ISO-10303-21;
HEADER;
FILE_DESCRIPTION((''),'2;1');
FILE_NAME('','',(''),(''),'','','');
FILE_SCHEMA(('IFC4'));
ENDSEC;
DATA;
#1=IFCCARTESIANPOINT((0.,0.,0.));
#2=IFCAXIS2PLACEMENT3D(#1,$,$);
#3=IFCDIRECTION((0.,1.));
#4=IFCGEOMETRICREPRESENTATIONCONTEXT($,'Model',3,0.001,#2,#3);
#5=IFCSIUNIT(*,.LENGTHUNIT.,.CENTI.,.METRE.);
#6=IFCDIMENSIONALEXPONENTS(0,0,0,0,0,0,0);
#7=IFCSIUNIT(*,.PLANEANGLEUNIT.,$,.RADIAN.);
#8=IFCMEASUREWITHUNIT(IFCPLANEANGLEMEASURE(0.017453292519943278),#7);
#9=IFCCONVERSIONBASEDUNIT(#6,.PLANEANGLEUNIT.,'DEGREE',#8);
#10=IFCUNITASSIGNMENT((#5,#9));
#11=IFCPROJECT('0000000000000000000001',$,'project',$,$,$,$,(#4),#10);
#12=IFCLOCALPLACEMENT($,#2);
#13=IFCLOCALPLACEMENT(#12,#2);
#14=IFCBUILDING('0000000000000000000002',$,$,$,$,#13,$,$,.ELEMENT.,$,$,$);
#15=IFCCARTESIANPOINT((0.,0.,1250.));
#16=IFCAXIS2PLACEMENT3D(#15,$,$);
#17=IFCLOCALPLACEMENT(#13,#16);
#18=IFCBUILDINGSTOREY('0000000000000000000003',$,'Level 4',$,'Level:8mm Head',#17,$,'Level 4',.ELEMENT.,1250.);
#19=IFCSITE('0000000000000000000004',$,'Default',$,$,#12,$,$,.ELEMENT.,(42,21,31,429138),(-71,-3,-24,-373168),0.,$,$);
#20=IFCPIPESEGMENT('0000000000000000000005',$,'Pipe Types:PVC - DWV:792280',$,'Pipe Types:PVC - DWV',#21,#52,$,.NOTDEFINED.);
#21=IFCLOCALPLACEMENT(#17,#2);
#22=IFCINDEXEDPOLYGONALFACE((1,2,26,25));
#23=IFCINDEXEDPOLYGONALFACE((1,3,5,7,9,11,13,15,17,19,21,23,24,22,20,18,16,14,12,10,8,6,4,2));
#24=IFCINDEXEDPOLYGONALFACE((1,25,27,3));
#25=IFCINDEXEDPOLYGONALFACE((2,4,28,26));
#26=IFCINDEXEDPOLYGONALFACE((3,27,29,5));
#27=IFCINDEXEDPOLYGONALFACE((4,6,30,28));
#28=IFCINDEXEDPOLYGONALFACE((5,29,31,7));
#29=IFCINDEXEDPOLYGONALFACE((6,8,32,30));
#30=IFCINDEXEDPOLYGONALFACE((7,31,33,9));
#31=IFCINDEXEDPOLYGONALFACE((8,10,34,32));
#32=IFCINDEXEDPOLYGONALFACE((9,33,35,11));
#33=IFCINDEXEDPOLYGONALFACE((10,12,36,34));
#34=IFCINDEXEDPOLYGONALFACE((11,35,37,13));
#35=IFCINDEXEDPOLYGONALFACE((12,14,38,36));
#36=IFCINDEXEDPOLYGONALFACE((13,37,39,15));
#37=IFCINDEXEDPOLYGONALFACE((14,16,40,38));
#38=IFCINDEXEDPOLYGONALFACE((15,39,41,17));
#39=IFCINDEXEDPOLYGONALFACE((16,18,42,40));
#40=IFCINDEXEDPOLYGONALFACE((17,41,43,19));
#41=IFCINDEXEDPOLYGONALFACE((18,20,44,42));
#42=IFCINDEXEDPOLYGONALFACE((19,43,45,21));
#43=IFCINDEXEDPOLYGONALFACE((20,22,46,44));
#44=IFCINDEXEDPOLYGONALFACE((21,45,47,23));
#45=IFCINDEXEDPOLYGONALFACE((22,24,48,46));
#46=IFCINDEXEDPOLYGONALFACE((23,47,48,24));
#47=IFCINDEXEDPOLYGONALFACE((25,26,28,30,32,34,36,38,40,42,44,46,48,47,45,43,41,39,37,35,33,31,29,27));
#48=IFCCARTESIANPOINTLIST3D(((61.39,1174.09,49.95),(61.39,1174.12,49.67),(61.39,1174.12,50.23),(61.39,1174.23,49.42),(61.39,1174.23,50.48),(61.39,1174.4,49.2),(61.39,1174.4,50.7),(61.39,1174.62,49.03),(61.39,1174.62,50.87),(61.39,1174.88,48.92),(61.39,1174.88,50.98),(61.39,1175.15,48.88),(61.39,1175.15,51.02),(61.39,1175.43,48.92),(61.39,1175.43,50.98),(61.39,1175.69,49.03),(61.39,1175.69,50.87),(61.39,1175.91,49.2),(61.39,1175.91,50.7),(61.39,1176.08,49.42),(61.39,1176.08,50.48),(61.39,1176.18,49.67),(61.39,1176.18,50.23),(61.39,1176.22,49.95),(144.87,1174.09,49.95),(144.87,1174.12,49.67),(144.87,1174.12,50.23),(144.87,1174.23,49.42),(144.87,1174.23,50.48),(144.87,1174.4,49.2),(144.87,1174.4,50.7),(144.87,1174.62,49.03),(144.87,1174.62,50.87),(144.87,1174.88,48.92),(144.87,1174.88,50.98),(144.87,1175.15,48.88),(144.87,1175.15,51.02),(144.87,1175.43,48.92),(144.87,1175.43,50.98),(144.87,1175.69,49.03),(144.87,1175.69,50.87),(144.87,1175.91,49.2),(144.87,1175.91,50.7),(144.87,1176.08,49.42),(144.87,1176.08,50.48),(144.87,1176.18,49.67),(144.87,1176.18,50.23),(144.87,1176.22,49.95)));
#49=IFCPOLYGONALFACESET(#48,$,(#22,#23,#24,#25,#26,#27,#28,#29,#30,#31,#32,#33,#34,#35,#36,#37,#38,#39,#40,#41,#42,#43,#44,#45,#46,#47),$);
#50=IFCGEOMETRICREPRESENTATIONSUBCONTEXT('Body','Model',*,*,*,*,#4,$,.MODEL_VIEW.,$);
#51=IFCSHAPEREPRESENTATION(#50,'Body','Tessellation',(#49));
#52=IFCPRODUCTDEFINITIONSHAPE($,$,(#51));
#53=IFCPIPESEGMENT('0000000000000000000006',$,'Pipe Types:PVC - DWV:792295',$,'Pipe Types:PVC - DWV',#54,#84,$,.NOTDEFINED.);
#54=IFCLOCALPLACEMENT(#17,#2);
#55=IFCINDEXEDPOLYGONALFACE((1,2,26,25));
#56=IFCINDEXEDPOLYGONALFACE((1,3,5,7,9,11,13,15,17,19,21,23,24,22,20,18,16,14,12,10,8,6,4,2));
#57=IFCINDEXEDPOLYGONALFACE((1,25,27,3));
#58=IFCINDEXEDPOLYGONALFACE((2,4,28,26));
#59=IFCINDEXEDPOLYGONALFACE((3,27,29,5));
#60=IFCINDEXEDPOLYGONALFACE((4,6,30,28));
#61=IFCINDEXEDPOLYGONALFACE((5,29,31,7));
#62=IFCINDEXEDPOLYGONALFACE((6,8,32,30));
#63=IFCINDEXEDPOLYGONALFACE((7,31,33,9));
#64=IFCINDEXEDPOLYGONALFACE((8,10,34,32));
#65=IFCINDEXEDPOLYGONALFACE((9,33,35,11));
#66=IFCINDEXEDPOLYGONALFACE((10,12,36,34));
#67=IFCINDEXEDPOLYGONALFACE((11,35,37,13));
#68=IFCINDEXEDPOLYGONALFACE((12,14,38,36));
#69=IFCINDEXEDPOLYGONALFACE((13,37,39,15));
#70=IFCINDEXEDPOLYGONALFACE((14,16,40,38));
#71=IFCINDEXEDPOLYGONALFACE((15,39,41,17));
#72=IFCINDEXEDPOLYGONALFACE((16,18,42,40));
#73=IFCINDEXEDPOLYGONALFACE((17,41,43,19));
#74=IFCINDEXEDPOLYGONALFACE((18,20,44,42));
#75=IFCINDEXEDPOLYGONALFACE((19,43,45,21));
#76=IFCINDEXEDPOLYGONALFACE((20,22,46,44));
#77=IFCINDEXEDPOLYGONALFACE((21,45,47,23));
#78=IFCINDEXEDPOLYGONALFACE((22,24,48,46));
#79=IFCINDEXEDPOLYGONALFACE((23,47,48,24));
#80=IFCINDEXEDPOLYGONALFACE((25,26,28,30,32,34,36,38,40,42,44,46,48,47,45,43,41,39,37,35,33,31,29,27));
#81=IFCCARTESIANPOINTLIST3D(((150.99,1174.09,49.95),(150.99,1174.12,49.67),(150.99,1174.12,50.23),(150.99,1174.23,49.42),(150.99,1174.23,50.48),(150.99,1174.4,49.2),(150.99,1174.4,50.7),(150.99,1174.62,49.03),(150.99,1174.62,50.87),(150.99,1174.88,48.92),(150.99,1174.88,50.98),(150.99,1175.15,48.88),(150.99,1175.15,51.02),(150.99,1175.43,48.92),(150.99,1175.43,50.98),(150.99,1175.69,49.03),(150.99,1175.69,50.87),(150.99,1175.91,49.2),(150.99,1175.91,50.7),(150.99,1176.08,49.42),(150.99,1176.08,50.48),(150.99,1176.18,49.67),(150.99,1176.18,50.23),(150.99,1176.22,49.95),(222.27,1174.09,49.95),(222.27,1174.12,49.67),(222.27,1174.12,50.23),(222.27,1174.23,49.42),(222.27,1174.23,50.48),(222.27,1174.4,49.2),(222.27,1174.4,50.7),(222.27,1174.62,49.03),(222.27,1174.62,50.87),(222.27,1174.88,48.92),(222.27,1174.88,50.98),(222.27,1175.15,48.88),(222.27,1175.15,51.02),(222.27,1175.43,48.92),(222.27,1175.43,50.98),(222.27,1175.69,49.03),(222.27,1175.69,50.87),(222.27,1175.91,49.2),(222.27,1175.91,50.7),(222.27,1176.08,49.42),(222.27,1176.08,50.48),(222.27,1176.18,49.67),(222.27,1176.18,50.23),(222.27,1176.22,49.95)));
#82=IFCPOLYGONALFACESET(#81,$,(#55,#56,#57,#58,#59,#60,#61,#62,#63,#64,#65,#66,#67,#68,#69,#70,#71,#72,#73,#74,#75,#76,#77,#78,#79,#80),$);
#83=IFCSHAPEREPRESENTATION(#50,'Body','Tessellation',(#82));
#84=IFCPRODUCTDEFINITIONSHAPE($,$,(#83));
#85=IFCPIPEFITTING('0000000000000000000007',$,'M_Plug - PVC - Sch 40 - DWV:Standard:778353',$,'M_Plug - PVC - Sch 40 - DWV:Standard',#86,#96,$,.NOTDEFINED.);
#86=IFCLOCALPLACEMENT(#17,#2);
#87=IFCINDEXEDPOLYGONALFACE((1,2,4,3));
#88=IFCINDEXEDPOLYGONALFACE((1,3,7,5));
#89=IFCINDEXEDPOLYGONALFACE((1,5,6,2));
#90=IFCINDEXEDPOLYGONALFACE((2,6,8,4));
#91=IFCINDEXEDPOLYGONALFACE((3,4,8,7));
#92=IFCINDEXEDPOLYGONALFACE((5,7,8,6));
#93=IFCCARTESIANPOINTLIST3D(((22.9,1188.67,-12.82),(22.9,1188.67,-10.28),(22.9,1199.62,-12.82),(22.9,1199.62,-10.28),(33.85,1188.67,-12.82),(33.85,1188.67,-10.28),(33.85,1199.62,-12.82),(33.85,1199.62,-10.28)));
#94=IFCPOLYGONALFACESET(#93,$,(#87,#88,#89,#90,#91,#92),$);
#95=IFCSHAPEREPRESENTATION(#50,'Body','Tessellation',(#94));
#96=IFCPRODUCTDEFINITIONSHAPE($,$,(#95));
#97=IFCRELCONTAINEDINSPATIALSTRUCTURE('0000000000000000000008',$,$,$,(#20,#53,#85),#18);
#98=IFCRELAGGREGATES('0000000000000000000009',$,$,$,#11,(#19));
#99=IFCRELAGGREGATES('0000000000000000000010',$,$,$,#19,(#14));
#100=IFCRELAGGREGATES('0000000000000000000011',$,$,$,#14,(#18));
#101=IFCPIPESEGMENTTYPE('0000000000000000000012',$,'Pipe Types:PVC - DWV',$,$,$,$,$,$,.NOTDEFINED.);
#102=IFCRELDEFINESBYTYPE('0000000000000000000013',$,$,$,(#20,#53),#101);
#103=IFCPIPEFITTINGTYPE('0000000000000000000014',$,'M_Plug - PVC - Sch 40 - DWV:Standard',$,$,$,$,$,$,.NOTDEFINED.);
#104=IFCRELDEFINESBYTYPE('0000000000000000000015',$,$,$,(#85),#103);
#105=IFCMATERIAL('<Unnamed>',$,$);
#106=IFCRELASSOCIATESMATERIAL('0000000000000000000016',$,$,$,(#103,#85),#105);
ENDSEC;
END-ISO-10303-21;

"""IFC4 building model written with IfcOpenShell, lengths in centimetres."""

from ifc_helpers import new_model, entity, si_unit, converted_unit, direction, frame, origin, place, context, subcontext, project, spatial, arc, indexed_curve, outline, extrude, source, transform, mapped, material, type_object, type_shapes, element, save


model = new_model("IFC4")

# Units and contexts
model_context = context("Model", 3, precision=0.001, world=origin(), true_north=direction((0.0, 1.0)))
body_context = subcontext(model_context, "Body", "Model", "MODEL_VIEW")
ifc_project = project(units=[si_unit("LENGTHUNIT", "METRE", prefix="CENTI"), converted_unit("PLANEANGLEUNIT", "DEGREE", entity("IfcPlaneAngleMeasure", 0.017453292519943278), si_unit("PLANEANGLEUNIT", "RADIAN"), dimensions=[0, 0, 0, 0, 0, 0, 0])], contexts=[model_context])

# Site, building, storey
site_placement = place(None, origin())
site = spatial("IfcSite", under=ifc_project, at=site_placement, Name="Default", CompositionType="ELEMENT", RefLatitude=(42, 21, 31, 429138), RefLongitude=(-71, -3, -24, -373168), RefElevation=0.0)
building_placement = place(site_placement, origin())
building = spatial("IfcBuilding", under=site, at=building_placement, CompositionType="ELEMENT")
storey_placement = place(building_placement, frame((0.0, 0.0, 1250.0)))
storey = spatial("IfcBuildingStorey", under=building, at=storey_placement, Name="Level 4", ObjectType="Level:8mm Head", LongName="Level 4", CompositionType="ELEMENT", Elevation=1250.0)

# Pipe segments
pipe_segment_type = type_object("IfcPipeSegmentType", Name="Pipe Types:PVC - DWV", PredefinedType="NOTDEFINED")
pipe_segment_1_placement = place(storey_placement, origin())
element("IfcPipeSegment", 1, at=pipe_segment_1_placement, inside=storey, type_object=pipe_segment_type, Name="Pipe Types:PVC - DWV:792280", ObjectType="Pipe Types:PVC - DWV", PredefinedType="NOTDEFINED", context=body_context, shape_type="SweptSolid", body=[
    extrude(outline(indexed_curve([(1.07, 0.0), (0.75, 0.75), (0.0, 1.07), (-0.75, 0.75), (-1.07, 0.0), (-0.75, -0.75), (0.0, -1.07), (0.75, -0.75)], segments=[arc(1, 2, 3), arc(3, 4, 5), arc(5, 6, 7), arc(7, 8, 1)], self_intersect=False)), frame((61.39, 1175.15, 49.95), z_axis=(1.0, 0.0, 0.0), x_axis=(0.0, 1.0, 0.0)), (0.0, 0.0, 1.0), 83.49),
])
pipe_segment_2_placement = place(storey_placement, origin())
element("IfcPipeSegment", 2, at=pipe_segment_2_placement, inside=storey, type_object=pipe_segment_type, Name="Pipe Types:PVC - DWV:792295", ObjectType="Pipe Types:PVC - DWV", PredefinedType="NOTDEFINED", context=body_context, shape_type="SweptSolid", body=[
    extrude(outline(indexed_curve([(1.07, 0.0), (0.75, 0.75), (0.0, 1.07), (-0.75, 0.75), (-1.07, 0.0), (-0.75, -0.75), (0.0, -1.07), (0.75, -0.75)], segments=[arc(1, 2, 3), arc(3, 4, 5), arc(5, 6, 7), arc(7, 8, 1)], self_intersect=False)), frame((150.99, 1175.15, 49.95), z_axis=(1.0, 0.0, 0.0), x_axis=(0.0, 1.0, 0.0)), (0.0, 0.0, 1.0), 71.29),
])

# Pipe fitting
ifc_material = material(Name="<Unnamed>")
pipe_fitting_type = type_object("IfcPipeFittingType", Name="M_Plug - PVC - Sch 40 - DWV:Standard", PredefinedType="NOTDEFINED", material=ifc_material)
shared_shape = source(origin(), body_context, "Body", "SweptSolid", [
    extrude(outline(indexed_curve([(-1.27, -5.48), (1.27, -5.48), (1.27, 5.48), (-1.27, 5.48), (-1.27, -5.48)], self_intersect=False)), frame((1.27, 0.0, -5.48), z_axis=(0.0, 0.0, 1.0), x_axis=(-1.0, 0.0, 0.0)), (0.0, 0.0, 1.0), 10.95),
])
type_shapes(pipe_fitting_type, [shared_shape])
pipe_fitting_placement = place(storey_placement, frame((28.38, 1194.14, -12.82), z_axis=(0.0, 1.0, 0.0), x_axis=(0.0, 0.0, 1.0)))
element("IfcPipeFitting", 3, at=pipe_fitting_placement, inside=storey, type_object=pipe_fitting_type, material=ifc_material, Name="M_Plug - PVC - Sch 40 - DWV:Standard:778353", ObjectType="M_Plug - PVC - Sch 40 - DWV:Standard", PredefinedType="NOTDEFINED", context=body_context, shape_type="MappedRepresentation", body=[
    mapped(shared_shape, transform((0.0, 0.0, 0.0), scale=1.0)),
])

save(model, "model.ifc")
